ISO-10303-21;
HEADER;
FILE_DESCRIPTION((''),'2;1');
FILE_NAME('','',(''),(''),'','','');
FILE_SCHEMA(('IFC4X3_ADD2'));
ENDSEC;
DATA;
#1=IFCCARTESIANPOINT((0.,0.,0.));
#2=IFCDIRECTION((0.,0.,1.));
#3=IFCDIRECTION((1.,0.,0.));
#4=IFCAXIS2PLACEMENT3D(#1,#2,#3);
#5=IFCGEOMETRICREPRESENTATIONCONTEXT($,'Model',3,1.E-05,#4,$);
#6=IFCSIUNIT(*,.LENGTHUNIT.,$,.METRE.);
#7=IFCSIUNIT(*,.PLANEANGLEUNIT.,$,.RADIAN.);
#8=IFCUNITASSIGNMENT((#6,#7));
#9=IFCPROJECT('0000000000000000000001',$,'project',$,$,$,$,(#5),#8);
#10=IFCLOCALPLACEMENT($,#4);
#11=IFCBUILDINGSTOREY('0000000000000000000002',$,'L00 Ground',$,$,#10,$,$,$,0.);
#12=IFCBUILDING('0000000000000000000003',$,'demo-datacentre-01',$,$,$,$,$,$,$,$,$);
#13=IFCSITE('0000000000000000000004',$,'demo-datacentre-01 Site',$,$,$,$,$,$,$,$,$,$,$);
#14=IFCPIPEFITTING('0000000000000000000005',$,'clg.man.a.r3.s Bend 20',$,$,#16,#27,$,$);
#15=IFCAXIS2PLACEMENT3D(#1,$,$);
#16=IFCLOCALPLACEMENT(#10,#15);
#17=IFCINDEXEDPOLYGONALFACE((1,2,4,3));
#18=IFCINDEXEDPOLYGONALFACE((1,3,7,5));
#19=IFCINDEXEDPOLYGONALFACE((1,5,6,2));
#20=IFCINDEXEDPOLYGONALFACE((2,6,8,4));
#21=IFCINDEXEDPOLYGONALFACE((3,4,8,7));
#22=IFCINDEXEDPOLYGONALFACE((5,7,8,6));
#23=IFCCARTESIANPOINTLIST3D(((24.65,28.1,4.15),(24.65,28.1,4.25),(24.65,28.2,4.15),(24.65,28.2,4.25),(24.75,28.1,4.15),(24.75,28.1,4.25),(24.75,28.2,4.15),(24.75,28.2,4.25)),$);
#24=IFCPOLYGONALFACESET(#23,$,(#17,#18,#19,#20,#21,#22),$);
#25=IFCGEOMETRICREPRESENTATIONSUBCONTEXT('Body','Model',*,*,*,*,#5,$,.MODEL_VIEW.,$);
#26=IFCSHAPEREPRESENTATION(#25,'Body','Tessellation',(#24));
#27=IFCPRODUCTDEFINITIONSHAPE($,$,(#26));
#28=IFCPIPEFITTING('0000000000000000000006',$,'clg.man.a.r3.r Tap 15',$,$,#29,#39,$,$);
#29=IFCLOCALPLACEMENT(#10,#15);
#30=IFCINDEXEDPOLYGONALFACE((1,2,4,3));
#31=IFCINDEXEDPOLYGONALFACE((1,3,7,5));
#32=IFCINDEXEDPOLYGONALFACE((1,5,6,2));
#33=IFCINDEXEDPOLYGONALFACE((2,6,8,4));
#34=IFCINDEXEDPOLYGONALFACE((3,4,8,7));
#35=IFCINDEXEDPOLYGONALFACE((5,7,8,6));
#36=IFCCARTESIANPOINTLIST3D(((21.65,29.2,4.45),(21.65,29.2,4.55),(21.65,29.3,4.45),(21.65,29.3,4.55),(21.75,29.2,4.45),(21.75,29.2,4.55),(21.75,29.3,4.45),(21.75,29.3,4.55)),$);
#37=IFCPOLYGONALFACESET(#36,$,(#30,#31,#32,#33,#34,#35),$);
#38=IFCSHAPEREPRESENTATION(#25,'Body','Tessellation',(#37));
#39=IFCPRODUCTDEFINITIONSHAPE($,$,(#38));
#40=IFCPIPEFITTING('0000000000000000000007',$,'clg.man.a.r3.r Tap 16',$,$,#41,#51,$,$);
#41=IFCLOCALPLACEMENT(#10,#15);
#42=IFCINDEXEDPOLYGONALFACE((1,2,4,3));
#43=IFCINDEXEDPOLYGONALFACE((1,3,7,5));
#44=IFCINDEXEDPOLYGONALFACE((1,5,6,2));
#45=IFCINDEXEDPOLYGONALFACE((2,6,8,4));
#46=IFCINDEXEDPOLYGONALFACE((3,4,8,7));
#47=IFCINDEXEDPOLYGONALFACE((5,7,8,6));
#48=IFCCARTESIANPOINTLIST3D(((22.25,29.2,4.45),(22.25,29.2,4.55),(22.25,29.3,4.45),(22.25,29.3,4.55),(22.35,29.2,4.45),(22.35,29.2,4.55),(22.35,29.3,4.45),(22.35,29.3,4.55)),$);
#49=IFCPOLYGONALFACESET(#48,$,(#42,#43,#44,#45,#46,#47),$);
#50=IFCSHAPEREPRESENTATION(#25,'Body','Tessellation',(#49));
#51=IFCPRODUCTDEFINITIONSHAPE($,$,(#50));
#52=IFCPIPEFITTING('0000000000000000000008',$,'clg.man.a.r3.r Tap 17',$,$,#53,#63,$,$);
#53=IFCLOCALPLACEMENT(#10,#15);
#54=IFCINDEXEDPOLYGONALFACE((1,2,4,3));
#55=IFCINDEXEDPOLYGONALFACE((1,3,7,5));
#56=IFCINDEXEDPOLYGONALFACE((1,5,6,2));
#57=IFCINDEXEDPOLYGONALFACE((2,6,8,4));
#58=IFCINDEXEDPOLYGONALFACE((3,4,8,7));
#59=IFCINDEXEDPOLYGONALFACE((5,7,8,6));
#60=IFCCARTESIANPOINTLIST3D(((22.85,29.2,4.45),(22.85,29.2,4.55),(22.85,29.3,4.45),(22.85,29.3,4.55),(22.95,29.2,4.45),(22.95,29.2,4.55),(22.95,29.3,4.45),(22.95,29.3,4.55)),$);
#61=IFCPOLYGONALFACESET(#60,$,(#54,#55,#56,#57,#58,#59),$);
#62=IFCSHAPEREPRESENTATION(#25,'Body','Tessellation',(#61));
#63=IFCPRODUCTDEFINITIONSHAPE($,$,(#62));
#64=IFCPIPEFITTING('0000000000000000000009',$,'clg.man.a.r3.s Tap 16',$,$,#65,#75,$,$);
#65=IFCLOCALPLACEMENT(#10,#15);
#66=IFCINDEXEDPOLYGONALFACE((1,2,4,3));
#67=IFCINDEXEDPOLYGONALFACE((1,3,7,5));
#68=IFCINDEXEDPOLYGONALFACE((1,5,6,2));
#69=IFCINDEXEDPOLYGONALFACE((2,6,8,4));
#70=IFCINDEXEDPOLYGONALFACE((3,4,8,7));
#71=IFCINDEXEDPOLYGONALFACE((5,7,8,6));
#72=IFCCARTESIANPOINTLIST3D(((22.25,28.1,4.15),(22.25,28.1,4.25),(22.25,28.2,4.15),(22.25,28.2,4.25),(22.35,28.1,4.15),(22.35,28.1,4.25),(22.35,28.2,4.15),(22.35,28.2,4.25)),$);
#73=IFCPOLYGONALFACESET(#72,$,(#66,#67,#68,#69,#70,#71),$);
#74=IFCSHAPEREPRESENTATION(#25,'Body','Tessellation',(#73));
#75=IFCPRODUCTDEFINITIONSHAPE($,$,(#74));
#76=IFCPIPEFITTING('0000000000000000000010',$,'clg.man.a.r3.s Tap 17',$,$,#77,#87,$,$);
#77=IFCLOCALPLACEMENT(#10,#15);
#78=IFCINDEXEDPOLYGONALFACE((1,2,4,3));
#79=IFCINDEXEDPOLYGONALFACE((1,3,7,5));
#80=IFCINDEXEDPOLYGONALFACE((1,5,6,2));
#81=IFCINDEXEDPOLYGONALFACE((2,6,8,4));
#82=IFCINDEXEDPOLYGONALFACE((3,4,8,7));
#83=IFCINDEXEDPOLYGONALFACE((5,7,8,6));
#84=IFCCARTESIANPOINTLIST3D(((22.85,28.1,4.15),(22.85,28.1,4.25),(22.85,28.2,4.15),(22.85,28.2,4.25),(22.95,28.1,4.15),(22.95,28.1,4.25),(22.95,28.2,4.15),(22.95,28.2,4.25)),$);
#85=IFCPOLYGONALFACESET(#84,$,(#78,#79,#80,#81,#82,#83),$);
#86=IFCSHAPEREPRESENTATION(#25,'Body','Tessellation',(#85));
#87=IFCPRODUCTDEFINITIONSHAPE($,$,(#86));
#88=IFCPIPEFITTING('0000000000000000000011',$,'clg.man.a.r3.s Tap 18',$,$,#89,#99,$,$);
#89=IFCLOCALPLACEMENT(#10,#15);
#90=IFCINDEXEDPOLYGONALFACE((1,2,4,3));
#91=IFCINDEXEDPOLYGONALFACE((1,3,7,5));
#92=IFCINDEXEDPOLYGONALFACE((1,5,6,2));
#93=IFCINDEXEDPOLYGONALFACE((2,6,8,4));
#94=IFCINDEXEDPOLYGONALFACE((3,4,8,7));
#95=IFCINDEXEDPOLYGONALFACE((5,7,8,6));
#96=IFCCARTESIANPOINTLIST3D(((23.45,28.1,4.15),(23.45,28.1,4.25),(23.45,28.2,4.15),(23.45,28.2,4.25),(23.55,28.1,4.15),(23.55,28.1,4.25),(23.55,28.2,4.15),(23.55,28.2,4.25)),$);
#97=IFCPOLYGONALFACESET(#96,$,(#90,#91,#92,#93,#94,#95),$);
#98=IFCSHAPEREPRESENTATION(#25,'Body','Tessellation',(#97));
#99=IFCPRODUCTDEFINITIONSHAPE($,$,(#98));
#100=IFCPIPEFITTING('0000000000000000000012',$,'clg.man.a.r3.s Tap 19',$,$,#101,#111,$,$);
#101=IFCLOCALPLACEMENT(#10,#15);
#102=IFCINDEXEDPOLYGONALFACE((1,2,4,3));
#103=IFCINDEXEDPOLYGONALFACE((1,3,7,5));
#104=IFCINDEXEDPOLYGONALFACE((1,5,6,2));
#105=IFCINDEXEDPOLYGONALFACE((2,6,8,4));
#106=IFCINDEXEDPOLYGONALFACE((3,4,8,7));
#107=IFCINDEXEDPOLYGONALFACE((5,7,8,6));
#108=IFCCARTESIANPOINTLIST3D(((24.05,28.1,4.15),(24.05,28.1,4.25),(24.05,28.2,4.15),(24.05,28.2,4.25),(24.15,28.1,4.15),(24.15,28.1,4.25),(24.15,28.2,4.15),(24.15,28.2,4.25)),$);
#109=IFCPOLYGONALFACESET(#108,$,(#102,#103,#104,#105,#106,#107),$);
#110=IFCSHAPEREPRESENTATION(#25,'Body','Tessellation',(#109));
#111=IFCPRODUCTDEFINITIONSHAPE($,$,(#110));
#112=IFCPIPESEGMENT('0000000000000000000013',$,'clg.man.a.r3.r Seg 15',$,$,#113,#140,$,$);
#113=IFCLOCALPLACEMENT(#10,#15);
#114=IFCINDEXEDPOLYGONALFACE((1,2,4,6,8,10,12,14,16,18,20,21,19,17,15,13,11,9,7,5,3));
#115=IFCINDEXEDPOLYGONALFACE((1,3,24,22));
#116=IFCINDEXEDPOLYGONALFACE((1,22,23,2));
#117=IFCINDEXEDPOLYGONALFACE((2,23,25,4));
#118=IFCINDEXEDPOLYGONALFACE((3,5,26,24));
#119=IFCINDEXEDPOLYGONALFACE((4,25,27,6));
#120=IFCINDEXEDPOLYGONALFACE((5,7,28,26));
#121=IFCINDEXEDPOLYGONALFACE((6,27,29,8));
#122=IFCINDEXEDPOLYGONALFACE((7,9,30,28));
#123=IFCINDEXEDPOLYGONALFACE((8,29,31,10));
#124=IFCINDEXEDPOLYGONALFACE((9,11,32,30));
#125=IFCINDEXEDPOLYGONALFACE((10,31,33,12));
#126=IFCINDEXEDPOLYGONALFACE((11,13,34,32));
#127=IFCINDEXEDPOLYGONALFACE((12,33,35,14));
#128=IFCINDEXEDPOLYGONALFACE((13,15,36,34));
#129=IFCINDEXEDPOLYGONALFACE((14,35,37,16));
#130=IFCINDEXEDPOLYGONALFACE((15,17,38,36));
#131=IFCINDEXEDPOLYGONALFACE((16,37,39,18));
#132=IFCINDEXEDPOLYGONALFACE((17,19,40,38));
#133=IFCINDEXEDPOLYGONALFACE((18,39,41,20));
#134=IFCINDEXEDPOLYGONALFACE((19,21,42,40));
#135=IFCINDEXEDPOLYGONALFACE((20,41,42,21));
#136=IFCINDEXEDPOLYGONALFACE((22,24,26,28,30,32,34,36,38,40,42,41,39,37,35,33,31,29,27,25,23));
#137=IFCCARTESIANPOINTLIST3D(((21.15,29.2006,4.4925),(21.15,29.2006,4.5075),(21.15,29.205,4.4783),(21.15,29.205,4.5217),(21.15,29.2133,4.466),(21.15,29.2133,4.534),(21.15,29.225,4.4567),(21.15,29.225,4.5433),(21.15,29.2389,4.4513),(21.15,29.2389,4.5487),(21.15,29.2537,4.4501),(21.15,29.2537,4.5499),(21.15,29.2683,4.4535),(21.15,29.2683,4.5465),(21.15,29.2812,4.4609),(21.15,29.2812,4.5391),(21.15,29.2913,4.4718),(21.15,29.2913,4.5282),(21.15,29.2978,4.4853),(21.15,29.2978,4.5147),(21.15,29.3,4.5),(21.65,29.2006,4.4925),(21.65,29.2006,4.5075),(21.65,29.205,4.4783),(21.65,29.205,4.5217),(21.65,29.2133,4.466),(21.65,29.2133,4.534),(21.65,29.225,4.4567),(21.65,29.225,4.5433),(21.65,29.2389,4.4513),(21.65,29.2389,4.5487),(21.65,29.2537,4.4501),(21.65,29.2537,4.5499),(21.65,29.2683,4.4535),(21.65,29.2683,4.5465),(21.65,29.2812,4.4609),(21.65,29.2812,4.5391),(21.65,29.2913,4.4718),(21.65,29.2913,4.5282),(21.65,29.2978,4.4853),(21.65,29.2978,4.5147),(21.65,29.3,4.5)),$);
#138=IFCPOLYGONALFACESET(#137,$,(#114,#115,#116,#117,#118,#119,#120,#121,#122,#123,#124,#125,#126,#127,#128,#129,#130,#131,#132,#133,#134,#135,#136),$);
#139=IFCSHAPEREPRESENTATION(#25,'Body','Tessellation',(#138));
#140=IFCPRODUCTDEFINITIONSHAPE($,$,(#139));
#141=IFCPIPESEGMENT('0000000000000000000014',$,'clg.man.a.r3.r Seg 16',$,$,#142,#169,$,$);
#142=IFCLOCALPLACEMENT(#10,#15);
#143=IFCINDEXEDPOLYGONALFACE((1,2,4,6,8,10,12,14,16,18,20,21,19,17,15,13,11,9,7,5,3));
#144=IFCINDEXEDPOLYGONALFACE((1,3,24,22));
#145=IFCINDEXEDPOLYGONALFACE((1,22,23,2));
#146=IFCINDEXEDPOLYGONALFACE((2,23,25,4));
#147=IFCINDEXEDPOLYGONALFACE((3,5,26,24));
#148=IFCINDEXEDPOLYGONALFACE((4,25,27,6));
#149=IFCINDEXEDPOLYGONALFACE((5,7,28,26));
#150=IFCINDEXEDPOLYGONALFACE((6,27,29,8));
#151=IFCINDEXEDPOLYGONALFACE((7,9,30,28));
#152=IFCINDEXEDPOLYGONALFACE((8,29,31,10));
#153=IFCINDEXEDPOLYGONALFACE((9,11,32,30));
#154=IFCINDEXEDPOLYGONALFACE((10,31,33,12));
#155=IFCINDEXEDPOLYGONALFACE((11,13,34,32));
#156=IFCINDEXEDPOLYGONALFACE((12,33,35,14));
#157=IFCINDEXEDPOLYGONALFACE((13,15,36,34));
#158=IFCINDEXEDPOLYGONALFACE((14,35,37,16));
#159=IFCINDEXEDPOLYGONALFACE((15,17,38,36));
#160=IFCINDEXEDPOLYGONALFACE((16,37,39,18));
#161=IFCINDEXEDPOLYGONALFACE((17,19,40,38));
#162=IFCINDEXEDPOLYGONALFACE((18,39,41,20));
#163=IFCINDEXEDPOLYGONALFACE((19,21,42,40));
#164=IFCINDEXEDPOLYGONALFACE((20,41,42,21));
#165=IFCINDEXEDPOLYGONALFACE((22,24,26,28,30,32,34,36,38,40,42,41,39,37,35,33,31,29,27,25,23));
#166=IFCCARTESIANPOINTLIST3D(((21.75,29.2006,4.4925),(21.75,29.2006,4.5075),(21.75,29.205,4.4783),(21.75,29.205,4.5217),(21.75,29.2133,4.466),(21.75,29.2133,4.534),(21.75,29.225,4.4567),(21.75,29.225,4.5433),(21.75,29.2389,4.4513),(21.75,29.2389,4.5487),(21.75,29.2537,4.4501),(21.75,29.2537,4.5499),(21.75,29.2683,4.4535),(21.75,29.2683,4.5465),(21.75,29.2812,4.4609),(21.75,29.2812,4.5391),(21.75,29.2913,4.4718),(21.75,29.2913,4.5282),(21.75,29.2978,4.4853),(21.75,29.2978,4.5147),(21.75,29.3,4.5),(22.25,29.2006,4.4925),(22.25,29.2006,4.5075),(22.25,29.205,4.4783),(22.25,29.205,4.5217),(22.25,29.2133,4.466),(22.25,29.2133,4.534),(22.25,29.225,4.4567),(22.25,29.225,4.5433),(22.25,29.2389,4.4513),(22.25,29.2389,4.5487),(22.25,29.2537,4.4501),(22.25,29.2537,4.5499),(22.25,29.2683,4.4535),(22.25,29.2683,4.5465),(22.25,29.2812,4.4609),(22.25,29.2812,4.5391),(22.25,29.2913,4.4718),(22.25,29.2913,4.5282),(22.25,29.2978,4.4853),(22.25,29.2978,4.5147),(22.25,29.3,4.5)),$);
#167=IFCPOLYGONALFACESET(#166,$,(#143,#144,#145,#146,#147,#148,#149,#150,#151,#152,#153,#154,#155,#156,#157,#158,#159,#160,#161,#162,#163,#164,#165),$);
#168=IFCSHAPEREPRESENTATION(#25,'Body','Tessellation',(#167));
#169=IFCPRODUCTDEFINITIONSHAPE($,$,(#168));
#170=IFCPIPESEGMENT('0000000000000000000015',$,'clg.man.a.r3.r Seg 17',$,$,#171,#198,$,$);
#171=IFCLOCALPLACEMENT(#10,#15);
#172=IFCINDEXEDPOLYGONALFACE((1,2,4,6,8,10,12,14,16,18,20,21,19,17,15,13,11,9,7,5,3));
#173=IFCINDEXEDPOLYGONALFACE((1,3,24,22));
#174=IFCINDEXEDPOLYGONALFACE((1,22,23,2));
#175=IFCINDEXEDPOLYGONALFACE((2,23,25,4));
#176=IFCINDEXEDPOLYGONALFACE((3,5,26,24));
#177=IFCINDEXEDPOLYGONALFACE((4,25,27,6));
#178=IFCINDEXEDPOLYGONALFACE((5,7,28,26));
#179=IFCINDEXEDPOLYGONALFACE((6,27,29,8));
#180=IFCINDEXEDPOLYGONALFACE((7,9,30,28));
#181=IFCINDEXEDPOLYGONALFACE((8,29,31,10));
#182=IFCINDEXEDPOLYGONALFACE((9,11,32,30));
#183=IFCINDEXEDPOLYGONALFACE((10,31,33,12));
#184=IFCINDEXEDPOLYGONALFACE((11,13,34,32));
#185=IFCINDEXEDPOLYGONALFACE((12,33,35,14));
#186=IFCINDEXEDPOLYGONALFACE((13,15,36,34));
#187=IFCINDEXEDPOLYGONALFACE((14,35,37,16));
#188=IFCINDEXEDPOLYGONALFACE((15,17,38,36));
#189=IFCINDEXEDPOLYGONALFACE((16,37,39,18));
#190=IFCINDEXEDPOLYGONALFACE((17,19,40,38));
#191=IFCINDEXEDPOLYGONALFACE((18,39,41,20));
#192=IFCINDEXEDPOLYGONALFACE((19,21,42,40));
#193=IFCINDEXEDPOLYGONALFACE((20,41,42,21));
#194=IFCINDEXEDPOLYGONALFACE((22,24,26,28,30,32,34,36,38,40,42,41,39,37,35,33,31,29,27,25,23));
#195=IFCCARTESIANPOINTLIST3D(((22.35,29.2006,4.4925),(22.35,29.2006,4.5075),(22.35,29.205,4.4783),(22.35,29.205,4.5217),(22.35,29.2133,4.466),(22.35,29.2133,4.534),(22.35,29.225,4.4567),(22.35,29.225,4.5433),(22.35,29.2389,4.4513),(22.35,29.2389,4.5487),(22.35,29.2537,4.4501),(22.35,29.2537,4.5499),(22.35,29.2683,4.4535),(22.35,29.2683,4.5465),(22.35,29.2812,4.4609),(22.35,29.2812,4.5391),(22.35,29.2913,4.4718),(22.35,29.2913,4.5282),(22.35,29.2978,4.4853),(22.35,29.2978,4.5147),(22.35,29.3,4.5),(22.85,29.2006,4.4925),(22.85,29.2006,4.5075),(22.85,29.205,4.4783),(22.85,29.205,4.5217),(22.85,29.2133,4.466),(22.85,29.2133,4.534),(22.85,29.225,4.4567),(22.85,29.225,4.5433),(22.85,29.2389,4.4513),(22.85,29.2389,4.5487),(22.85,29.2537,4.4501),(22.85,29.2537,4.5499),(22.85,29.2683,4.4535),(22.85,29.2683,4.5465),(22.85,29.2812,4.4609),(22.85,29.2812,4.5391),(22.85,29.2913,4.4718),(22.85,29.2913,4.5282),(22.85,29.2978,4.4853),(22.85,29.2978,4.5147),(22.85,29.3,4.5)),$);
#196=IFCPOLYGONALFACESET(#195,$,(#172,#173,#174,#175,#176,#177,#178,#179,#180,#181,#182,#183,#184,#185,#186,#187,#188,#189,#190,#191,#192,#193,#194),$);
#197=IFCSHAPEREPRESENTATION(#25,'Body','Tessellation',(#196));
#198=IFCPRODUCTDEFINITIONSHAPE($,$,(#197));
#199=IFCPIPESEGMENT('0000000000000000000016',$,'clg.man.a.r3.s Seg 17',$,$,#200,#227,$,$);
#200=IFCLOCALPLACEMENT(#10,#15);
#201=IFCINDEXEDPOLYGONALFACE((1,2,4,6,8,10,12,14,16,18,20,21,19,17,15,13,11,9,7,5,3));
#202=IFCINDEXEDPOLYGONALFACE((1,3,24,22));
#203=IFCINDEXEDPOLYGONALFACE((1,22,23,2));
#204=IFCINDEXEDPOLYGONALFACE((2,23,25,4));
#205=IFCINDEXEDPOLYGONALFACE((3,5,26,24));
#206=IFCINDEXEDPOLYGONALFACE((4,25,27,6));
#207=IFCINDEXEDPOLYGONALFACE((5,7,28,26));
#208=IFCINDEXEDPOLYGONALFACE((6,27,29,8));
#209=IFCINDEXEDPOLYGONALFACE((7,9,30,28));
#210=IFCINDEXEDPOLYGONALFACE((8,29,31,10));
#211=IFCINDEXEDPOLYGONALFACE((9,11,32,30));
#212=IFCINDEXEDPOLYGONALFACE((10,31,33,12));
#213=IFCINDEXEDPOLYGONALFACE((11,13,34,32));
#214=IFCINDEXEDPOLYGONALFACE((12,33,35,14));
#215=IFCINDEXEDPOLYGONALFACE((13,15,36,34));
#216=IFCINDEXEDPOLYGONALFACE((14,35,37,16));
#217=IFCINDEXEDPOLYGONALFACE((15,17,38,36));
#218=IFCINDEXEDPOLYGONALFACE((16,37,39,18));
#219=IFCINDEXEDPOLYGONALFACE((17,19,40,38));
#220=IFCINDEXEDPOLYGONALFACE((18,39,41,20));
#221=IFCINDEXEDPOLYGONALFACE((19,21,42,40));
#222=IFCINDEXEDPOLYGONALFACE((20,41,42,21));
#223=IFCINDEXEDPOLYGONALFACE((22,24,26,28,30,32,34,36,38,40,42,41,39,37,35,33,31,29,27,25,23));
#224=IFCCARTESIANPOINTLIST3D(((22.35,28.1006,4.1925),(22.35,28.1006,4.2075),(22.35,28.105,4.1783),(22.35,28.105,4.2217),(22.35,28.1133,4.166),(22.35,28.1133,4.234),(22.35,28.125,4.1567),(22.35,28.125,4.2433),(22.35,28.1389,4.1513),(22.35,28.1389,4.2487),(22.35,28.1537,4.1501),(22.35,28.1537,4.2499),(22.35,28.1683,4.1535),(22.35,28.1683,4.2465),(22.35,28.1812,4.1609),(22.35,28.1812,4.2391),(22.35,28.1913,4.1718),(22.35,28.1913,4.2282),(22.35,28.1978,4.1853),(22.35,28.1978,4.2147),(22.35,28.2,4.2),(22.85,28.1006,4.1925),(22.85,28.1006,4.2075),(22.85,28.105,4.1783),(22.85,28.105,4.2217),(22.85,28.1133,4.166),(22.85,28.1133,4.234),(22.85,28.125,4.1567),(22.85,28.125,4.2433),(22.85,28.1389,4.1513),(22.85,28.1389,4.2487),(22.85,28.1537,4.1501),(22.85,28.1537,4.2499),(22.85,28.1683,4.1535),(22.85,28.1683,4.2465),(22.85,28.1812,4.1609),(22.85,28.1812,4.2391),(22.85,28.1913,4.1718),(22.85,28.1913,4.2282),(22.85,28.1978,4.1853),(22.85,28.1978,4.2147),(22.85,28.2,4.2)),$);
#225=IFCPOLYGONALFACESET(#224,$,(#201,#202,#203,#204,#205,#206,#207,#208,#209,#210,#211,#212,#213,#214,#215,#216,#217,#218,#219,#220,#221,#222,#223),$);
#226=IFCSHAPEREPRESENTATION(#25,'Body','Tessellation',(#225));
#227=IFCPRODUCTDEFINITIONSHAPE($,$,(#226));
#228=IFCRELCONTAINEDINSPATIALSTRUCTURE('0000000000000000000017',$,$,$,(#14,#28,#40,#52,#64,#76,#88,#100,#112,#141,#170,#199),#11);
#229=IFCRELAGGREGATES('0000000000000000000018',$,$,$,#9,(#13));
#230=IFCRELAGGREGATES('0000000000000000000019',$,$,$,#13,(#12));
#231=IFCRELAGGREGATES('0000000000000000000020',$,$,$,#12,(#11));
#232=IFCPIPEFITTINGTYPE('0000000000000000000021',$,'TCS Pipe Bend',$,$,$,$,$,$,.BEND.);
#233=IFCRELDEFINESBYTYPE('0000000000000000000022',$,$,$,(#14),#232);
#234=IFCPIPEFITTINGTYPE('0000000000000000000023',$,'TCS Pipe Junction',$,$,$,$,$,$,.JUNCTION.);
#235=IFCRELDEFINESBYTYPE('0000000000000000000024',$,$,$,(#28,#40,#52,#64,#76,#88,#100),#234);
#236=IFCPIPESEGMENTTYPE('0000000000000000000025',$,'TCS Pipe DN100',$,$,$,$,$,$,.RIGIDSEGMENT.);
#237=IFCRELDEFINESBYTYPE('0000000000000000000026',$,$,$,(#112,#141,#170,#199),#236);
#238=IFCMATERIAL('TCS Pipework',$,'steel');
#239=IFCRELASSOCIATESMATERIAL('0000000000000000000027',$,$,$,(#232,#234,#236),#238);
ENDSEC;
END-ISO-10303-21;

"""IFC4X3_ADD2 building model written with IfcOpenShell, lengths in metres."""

from ifc_helpers import new_model, si_unit, frame, origin_with_axes, place, context, subcontext, project, spatial, rectangle, circle, extrude, material, type_object, element, save


model = new_model("IFC4X3_ADD2")

# Units and contexts
model_context = context("Model", 3, precision=1e-05, world=origin_with_axes())
body_context = subcontext(model_context, "Body", "Model", "MODEL_VIEW")
ifc_project = project(units=[si_unit("LENGTHUNIT", "METRE"), si_unit("PLANEANGLEUNIT", "RADIAN")], contexts=[model_context])

# Site, building, storey
site = spatial("IfcSite", under=ifc_project, Name="demo-datacentre-01 Site")
building = spatial("IfcBuilding", under=site, Name="demo-datacentre-01")
storey_placement = place(None, origin_with_axes())
storey = spatial("IfcBuildingStorey", under=building, at=storey_placement, Name="L00 Ground", Elevation=0.0)

# Pipe fittings
ifc_material = material(Name="TCS Pipework", Category="steel")
pipe_fitting_type_1 = type_object("IfcPipeFittingType", Name="TCS Pipe Bend", PredefinedType="BEND", material=ifc_material)
pipe_fitting_placement = place(storey_placement, frame((24.7, 28.15, 4.15), z_axis=(0.0, 0.0, 1.0), x_axis=(1.0, 0.0, 0.0)))
element("IfcPipeFitting", 1, at=pipe_fitting_placement, inside=storey, type_object=pipe_fitting_type_1, Name="clg.man.a.r3.s Bend 20", context=body_context, shape_type="SweptSolid", body=[
    extrude(rectangle(XDim=0.1, YDim=0.1), origin_with_axes(), (0.0, 0.0, 1.0), 0.1),
])
pipe_fitting_type_2 = type_object("IfcPipeFittingType", Name="TCS Pipe Junction", PredefinedType="JUNCTION", material=ifc_material)
for number, where, z_axis, x_axis, name in (
    (2, (21.7, 29.25, 4.45), (0.0, 0.0, 1.0), (1.0, 0.0, 0.0), "clg.man.a.r3.r Tap 15"),
    (3, (22.3, 29.25, 4.45), (0.0, 0.0, 1.0), (1.0, 0.0, 0.0), "clg.man.a.r3.r Tap 16"),
    (4, (22.9, 29.25, 4.45), (0.0, 0.0, 1.0), (1.0, 0.0, 0.0), "clg.man.a.r3.r Tap 17"),
    (5, (22.3, 28.15, 4.15), (0.0, 0.0, 1.0), (1.0, 0.0, 0.0), "clg.man.a.r3.s Tap 16"),
    (6, (22.9, 28.15, 4.15), (0.0, 0.0, 1.0), (1.0, 0.0, 0.0), "clg.man.a.r3.s Tap 17"),
    (7, (23.5, 28.15, 4.15), (0.0, 0.0, 1.0), (1.0, 0.0, 0.0), "clg.man.a.r3.s Tap 18"),
    (8, (24.1, 28.15, 4.15), (0.0, 0.0, 1.0), (1.0, 0.0, 0.0), "clg.man.a.r3.s Tap 19"),
):
    element("IfcPipeFitting", number, at=place(storey_placement, frame(where, z_axis=z_axis, x_axis=x_axis)), inside=storey, type_object=pipe_fitting_type_2, Name=name, context=body_context, shape_type="SweptSolid", body=[
        extrude(rectangle(XDim=0.1, YDim=0.1), origin_with_axes(), (0.0, 0.0, 1.0), 0.1),
    ])

# Pipe segments
pipe_segment_type_1 = type_object("IfcPipeSegmentType", Name="TCS Pipe DN100", PredefinedType="RIGIDSEGMENT", material=ifc_material)
pipe_segment_placement = place(storey_placement, frame((21.15, 29.25, 4.5), z_axis=(1.0, 0.0, 0.0), x_axis=(0.0, 1.0, 0.0)))
element("IfcPipeSegment", 9, at=pipe_segment_placement, inside=storey, type_object=pipe_segment_type_1, Name="clg.man.a.r3.r Seg 15", context=body_context, shape_type="SweptSolid", body=[
    extrude(circle(Radius=0.05), origin_with_axes(), (0.0, 0.0, 1.0), 0.5),
])
for number, where, z_axis, x_axis, name in (
    (10, (21.75, 29.25, 4.5), (1.0, 0.0, 0.0), (0.0, 1.0, 0.0), "clg.man.a.r3.r Seg 16"),
    (11, (22.35, 29.25, 4.5), (1.0, 0.0, 0.0), (0.0, 1.0, 0.0), "clg.man.a.r3.r Seg 17"),
    (12, (22.35, 28.15, 4.2), (1.0, 0.0, 0.0), (0.0, 1.0, 0.0), "clg.man.a.r3.s Seg 17"),
):
    element("IfcPipeSegment", number, at=place(storey_placement, frame(where, z_axis=z_axis, x_axis=x_axis)), inside=storey, type_object=pipe_segment_type_1, Name=name, context=body_context, shape_type="SweptSolid", body=[
        extrude(circle(Radius=0.05), origin_with_axes(), (0.0, 0.0, 1.0), 0.5),
    ])

save(model, "model.ifc")
